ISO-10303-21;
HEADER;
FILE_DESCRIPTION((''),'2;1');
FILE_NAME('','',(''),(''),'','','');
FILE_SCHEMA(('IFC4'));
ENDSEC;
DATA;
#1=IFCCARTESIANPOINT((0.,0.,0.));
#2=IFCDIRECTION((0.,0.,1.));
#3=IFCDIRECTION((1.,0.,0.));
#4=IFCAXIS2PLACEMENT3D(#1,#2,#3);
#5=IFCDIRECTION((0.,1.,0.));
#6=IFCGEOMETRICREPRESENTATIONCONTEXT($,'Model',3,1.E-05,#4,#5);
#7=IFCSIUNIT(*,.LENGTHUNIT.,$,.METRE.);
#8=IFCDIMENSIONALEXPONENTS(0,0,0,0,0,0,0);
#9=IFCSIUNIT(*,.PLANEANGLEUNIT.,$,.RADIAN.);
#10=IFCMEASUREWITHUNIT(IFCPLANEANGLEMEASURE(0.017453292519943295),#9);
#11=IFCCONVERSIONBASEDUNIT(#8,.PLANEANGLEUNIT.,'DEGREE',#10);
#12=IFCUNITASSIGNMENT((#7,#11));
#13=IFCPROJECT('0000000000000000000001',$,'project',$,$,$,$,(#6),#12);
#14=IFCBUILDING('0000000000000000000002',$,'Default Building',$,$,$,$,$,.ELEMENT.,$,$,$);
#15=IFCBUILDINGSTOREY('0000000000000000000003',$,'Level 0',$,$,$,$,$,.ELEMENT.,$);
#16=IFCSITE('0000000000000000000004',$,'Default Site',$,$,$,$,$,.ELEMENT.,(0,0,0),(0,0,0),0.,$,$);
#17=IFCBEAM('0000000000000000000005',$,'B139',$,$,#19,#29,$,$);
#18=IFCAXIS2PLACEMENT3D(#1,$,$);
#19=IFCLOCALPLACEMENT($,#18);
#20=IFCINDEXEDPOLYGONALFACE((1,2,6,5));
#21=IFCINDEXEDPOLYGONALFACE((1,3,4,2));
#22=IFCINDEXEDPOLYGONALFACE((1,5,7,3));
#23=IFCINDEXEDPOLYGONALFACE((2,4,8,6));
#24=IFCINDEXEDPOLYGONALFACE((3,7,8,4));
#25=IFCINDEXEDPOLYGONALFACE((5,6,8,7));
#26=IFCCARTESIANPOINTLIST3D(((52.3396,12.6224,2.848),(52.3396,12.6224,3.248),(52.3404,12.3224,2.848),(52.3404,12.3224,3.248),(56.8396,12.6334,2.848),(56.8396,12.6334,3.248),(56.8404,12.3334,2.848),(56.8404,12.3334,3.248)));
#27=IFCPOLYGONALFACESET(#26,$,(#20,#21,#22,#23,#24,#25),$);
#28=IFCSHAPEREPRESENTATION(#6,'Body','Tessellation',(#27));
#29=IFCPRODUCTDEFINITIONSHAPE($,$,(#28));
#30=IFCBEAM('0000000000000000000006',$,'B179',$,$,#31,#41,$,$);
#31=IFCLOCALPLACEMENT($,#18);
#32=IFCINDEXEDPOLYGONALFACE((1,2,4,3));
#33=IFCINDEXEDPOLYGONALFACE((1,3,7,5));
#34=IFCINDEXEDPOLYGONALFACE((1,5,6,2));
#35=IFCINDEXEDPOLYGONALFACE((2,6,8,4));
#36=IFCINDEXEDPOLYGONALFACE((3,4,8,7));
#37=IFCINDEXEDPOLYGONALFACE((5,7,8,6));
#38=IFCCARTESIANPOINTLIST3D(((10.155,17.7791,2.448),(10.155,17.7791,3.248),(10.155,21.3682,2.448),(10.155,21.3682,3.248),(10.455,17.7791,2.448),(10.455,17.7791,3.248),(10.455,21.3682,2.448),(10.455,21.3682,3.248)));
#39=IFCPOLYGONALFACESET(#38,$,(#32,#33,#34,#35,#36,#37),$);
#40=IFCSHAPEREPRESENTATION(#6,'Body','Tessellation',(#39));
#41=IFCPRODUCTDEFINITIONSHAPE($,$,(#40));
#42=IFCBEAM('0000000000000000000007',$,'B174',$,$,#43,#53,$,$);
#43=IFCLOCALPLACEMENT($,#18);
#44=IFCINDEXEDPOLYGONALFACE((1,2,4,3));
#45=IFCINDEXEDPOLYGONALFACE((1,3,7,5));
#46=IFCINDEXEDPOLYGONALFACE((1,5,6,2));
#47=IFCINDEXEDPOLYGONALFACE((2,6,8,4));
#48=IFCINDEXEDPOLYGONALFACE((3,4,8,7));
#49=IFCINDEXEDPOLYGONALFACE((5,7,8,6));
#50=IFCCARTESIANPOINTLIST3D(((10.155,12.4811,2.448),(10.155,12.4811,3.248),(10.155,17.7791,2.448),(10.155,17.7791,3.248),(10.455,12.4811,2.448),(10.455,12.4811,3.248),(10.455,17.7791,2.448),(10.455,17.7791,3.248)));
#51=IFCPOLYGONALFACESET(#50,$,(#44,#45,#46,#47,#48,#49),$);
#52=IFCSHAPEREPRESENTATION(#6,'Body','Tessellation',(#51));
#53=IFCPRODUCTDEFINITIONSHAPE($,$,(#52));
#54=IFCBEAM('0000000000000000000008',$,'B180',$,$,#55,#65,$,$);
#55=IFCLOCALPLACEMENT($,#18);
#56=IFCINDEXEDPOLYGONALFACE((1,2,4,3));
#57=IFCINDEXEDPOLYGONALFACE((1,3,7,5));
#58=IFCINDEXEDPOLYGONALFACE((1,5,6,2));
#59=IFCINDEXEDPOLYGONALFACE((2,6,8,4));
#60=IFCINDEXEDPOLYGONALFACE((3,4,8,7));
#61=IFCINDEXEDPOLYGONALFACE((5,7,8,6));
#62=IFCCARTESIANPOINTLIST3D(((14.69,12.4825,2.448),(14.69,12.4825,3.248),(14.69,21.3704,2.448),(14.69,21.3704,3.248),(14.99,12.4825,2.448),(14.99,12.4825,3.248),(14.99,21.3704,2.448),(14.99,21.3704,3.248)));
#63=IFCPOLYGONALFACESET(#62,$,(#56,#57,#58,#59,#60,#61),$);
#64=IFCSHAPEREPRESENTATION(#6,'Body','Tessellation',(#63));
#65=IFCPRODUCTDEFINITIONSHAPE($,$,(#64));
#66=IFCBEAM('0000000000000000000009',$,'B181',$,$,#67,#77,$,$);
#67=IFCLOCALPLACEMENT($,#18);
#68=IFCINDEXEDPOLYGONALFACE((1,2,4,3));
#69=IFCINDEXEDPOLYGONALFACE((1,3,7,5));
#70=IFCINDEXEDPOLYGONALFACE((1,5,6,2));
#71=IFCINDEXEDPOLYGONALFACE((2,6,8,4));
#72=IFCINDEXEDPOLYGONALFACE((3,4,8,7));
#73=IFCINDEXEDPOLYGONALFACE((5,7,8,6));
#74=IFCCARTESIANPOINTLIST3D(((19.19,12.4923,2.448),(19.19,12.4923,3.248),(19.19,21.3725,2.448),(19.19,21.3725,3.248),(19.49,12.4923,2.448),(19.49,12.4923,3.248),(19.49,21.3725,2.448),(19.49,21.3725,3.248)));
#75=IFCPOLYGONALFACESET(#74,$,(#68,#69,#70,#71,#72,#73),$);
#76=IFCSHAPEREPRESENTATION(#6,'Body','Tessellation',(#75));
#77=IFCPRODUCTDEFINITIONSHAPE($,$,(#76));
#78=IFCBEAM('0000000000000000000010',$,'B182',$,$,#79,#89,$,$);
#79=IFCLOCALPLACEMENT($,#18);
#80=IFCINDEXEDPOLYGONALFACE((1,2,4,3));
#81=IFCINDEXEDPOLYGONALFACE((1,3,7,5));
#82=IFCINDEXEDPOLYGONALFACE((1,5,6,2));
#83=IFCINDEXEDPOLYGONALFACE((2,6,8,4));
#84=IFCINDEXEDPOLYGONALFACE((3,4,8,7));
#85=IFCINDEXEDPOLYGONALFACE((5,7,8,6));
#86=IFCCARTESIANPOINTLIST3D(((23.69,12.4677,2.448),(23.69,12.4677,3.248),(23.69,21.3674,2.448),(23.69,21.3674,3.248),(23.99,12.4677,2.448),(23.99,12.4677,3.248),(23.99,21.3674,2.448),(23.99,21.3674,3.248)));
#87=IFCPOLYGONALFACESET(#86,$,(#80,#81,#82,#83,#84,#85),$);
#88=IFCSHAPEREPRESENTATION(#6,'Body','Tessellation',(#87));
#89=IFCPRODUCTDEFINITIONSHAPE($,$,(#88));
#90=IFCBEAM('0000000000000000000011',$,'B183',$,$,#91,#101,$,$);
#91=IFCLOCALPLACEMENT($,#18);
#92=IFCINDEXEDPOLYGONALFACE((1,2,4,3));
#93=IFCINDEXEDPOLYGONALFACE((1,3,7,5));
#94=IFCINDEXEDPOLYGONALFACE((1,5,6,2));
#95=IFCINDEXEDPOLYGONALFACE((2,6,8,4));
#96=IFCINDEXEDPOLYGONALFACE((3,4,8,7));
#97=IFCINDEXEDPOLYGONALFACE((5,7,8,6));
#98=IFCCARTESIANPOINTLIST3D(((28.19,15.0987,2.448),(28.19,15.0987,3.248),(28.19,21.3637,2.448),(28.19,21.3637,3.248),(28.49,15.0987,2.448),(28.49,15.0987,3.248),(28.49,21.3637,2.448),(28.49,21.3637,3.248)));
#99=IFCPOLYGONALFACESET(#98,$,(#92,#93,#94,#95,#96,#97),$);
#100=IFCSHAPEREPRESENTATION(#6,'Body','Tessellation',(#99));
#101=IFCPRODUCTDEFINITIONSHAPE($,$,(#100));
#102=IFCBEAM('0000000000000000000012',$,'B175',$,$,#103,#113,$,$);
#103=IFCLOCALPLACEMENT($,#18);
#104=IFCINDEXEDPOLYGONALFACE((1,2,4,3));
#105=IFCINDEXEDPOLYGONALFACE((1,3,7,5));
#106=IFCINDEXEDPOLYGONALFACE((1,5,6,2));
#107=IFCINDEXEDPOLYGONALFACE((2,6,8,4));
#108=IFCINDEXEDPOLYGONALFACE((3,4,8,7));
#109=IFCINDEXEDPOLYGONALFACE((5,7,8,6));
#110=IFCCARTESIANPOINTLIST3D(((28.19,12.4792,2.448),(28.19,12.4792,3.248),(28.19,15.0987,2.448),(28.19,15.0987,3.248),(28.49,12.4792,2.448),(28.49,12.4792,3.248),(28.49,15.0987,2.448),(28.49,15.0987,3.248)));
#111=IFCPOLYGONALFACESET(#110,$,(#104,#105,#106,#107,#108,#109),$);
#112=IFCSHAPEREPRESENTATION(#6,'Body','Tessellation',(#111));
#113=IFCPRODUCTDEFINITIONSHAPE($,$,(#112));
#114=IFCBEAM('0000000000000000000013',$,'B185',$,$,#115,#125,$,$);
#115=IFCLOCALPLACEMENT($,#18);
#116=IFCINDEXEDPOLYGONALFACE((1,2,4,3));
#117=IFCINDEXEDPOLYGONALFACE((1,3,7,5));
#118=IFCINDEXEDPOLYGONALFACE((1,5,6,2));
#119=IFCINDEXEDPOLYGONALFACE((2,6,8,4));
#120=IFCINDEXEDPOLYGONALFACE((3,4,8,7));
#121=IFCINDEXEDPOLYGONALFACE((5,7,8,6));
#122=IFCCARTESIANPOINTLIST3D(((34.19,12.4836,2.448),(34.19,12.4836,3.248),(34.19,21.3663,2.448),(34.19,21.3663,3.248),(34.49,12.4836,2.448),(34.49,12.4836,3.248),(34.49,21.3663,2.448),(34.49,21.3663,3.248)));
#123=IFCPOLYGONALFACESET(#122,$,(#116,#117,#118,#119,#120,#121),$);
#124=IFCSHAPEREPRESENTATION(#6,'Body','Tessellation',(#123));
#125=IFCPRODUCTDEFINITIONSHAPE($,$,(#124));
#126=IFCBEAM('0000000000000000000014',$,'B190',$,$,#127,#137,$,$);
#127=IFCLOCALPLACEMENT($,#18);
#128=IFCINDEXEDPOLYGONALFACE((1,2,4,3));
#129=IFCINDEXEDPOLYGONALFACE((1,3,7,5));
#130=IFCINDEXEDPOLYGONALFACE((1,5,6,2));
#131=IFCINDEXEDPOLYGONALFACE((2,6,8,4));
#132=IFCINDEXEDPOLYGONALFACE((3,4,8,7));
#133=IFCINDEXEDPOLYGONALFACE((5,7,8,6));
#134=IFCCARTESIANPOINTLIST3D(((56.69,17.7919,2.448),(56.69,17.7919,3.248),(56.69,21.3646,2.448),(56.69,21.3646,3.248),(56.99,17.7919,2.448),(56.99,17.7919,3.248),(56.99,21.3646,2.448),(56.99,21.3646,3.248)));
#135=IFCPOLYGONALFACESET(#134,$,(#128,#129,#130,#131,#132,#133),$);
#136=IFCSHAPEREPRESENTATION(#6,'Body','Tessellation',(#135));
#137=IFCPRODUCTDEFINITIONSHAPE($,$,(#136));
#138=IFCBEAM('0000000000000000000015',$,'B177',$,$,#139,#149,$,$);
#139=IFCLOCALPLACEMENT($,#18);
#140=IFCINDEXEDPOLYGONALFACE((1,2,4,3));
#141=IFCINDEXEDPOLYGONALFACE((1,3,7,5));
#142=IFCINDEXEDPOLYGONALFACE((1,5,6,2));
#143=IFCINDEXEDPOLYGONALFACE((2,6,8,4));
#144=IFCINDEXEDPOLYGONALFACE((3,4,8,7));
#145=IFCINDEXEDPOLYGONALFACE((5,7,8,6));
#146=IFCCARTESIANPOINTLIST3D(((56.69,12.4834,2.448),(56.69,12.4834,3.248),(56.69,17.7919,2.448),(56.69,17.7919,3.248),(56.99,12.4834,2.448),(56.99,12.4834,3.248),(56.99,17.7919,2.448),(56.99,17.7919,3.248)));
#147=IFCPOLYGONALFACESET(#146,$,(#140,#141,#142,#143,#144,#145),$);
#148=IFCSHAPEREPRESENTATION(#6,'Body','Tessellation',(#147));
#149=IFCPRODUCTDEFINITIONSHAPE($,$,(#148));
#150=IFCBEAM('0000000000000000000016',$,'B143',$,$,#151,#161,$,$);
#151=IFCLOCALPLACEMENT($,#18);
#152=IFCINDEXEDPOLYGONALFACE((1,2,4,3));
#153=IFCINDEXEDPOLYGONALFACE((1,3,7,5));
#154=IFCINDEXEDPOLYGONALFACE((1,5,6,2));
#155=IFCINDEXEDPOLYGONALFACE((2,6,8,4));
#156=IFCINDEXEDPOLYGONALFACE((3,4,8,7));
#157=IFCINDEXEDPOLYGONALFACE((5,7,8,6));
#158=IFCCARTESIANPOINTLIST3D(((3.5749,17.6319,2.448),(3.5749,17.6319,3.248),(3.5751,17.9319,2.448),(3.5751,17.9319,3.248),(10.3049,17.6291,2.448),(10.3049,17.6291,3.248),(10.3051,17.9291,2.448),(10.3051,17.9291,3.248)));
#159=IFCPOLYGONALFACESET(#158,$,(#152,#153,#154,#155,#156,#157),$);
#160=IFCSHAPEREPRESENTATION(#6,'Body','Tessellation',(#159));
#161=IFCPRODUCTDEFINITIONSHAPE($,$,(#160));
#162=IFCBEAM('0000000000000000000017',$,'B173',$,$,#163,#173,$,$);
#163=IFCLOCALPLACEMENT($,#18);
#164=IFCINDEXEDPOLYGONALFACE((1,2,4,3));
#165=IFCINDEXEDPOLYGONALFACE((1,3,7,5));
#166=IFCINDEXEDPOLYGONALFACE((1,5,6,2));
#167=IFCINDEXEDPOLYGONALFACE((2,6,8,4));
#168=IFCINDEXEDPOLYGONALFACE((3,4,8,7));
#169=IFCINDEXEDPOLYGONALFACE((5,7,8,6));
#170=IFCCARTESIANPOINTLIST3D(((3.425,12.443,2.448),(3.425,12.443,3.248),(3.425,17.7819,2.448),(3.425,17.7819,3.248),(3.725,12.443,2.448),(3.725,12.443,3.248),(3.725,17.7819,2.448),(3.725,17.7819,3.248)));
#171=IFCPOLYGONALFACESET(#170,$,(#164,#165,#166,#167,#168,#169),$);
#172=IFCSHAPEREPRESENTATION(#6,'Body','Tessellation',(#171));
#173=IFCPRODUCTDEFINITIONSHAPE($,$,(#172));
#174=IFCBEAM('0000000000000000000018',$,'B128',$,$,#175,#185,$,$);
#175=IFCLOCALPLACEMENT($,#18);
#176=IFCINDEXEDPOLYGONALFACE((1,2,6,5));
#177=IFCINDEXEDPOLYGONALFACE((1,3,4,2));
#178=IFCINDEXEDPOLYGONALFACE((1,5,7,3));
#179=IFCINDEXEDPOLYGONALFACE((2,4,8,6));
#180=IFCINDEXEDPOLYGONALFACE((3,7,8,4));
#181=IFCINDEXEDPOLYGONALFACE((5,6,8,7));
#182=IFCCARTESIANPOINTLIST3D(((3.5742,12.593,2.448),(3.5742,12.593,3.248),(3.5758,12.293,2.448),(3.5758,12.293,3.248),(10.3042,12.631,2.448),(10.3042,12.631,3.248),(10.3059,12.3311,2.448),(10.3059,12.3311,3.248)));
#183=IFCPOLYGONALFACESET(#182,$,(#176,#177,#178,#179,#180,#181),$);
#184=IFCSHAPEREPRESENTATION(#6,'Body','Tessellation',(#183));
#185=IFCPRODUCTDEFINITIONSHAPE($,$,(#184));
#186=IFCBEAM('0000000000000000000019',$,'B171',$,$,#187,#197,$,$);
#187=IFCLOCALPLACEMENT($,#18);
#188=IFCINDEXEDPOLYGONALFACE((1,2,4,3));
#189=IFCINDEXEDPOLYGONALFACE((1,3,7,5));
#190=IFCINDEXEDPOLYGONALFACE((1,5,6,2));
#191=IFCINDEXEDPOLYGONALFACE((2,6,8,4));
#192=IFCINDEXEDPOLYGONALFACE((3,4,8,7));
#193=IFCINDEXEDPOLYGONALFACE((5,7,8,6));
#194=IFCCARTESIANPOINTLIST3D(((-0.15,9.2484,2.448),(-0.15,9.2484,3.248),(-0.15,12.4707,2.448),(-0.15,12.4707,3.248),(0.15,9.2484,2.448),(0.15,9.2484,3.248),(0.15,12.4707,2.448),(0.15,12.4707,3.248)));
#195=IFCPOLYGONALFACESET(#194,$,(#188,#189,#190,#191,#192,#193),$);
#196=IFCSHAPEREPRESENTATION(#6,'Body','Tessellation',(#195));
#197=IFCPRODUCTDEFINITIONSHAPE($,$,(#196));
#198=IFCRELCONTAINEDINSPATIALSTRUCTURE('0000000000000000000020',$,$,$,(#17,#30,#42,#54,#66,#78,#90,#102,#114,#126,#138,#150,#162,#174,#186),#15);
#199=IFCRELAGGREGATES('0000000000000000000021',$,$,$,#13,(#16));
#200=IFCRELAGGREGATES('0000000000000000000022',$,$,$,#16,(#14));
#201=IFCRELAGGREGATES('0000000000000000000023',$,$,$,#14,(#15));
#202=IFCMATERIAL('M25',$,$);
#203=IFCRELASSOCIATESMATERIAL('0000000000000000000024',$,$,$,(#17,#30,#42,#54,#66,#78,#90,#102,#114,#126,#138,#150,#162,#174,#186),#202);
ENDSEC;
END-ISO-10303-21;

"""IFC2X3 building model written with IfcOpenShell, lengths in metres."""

from ifc_helpers import new_model, entity, si_unit, converted_unit, direction, frame, frame_2d, origin_with_axes, place, context, project, spatial, rectangle, extrude, material, element, save


model = new_model("IFC2X3")

# Units and contexts
model_context = context("Model", 3, precision=1e-05, world=origin_with_axes(), true_north=direction((0.0, 1.0, 0.0)))
ifc_project = project(units=[si_unit("LENGTHUNIT", "METRE"), converted_unit("PLANEANGLEUNIT", "DEGREE", entity("IfcPlaneAngleMeasure", 0.017453292519943295), si_unit("PLANEANGLEUNIT", "RADIAN"), dimensions=[0, 0, 0, 0, 0, 0, 0])], contexts=[model_context])

# Site, building, storey
site = spatial("IfcSite", under=ifc_project, Name="Default Site", CompositionType="ELEMENT", RefLatitude=(0, 0, 0), RefLongitude=(0, 0, 0), RefElevation=0.0)
building = spatial("IfcBuilding", under=site, Name="Default Building", CompositionType="ELEMENT")
storey = spatial("IfcBuildingStorey", under=building, Name="Level 0", CompositionType="ELEMENT")

# Beams
ifc_material = material(Name="M25")
placement = place(None, origin_with_axes())
element("IfcBeam", 1, at=placement, inside=storey, material=ifc_material, Name="B139", context=model_context, shape_type="SweptSolid", body=[
    extrude(rectangle(XDim=0.3, YDim=0.4, at=frame_2d((0.0, 0.0), x_axis=(0.0, 1.0, 0.0))), frame((52.34, 12.4724, 3.048), z_axis=(0.999997, 0.002456, 0.0), x_axis=(0.0, 0.0, -1.0)), (0.0, 0.0, 1.0), 4.5),
])
element("IfcBeam", 2, at=placement, inside=storey, material=ifc_material, Name="B179", context=model_context, shape_type="SweptSolid", body=[
    extrude(rectangle(XDim=0.3, YDim=0.8, at=frame_2d((0.0, 0.0), x_axis=(0.0, 1.0, 0.0))), frame((10.305, 21.3682, 2.848), z_axis=(0.0, -1.0, 0.0), x_axis=(0.0, 0.0, -1.0)), (0.0, 0.0, 1.0), 3.5891),
])
element("IfcBeam", 3, at=placement, inside=storey, material=ifc_material, Name="B174", context=model_context, shape_type="SweptSolid", body=[
    extrude(rectangle(XDim=0.3, YDim=0.8, at=frame_2d((0.0, 0.0), x_axis=(0.0, 1.0, 0.0))), frame((10.305, 17.7791, 2.848), z_axis=(0.0, -1.0, 0.0), x_axis=(0.0, 0.0, -1.0)), (0.0, 0.0, 1.0), 5.298),
])
element("IfcBeam", 4, at=placement, inside=storey, material=ifc_material, Name="B180", context=model_context, shape_type="SweptSolid", body=[
    extrude(rectangle(XDim=0.3, YDim=0.8, at=frame_2d((0.0, 0.0), x_axis=(0.0, 1.0, 0.0))), frame((14.84, 21.3704, 2.848), z_axis=(0.0, -1.0, 0.0), x_axis=(0.0, 0.0, -1.0)), (0.0, 0.0, 1.0), 8.8879),
])
element("IfcBeam", 5, at=placement, inside=storey, material=ifc_material, Name="B181", context=model_context, shape_type="SweptSolid", body=[
    extrude(rectangle(XDim=0.3, YDim=0.8, at=frame_2d((0.0, 0.0), x_axis=(0.0, 1.0, 0.0))), frame((19.34, 21.3725, 2.848), z_axis=(0.0, -1.0, 0.0), x_axis=(0.0, 0.0, -1.0)), (0.0, 0.0, 1.0), 8.8802),
])
element("IfcBeam", 6, at=placement, inside=storey, material=ifc_material, Name="B182", context=model_context, shape_type="SweptSolid", body=[
    extrude(rectangle(XDim=0.3, YDim=0.8, at=frame_2d((0.0, 0.0), x_axis=(0.0, 1.0, 0.0))), frame((23.84, 21.3674, 2.848), z_axis=(0.0, -1.0, 0.0), x_axis=(0.0, 0.0, -1.0)), (0.0, 0.0, 1.0), 8.8997),
])
element("IfcBeam", 7, at=placement, inside=storey, material=ifc_material, Name="B183", context=model_context, shape_type="SweptSolid", body=[
    extrude(rectangle(XDim=0.3, YDim=0.8, at=frame_2d((0.0, 0.0), x_axis=(0.0, 1.0, 0.0))), frame((28.34, 21.3637, 2.848), z_axis=(0.0, -1.0, 0.0), x_axis=(0.0, 0.0, -1.0)), (0.0, 0.0, 1.0), 6.265),
])
element("IfcBeam", 8, at=placement, inside=storey, material=ifc_material, Name="B175", context=model_context, shape_type="SweptSolid", body=[
    extrude(rectangle(XDim=0.3, YDim=0.8, at=frame_2d((0.0, 0.0), x_axis=(0.0, 1.0, 0.0))), frame((28.34, 15.0987, 2.848), z_axis=(0.0, -1.0, 0.0), x_axis=(0.0, 0.0, -1.0)), (0.0, 0.0, 1.0), 2.6195),
])
element("IfcBeam", 9, at=placement, inside=storey, material=ifc_material, Name="B185", context=model_context, shape_type="SweptSolid", body=[
    extrude(rectangle(XDim=0.3, YDim=0.8, at=frame_2d((0.0, 0.0), x_axis=(0.0, 1.0, 0.0))), frame((34.34, 12.4836, 2.848), z_axis=(0.0, 1.0, 0.0), x_axis=(0.0, 0.0, -1.0)), (0.0, 0.0, 1.0), 8.8827),
])
element("IfcBeam", 10, at=placement, inside=storey, material=ifc_material, Name="B190", context=model_context, shape_type="SweptSolid", body=[
    extrude(rectangle(XDim=0.3, YDim=0.8, at=frame_2d((0.0, 0.0), x_axis=(0.0, 1.0, 0.0))), frame((56.84, 17.7919, 2.848), z_axis=(0.0, 1.0, 0.0), x_axis=(0.0, 0.0, -1.0)), (0.0, 0.0, 1.0), 3.5727),
])
element("IfcBeam", 11, at=placement, inside=storey, material=ifc_material, Name="B177", context=model_context, shape_type="SweptSolid", body=[
    extrude(rectangle(XDim=0.3, YDim=0.8, at=frame_2d((0.0, 0.0), x_axis=(0.0, 1.0, 0.0))), frame((56.84, 12.4834, 2.848), z_axis=(0.0, 1.0, 0.0), x_axis=(0.0, 0.0, -1.0)), (0.0, 0.0, 1.0), 5.3085),
])
element("IfcBeam", 12, at=placement, inside=storey, material=ifc_material, Name="B143", context=model_context, shape_type="SweptSolid", body=[
    extrude(rectangle(XDim=0.3, YDim=0.8, at=frame_2d((0.0, 0.0), x_axis=(0.0, 1.0, 0.0))), frame((10.305, 17.7791, 2.848), z_axis=(-1.0, 0.000419, 0.0), x_axis=(0.0, 0.0, -1.0)), (0.0, 0.0, 1.0), 6.73),
])
element("IfcBeam", 13, at=placement, inside=storey, material=ifc_material, Name="B173", context=model_context, shape_type="SweptSolid", body=[
    extrude(rectangle(XDim=0.3, YDim=0.8, at=frame_2d((0.0, 0.0), x_axis=(0.0, 1.0, 0.0))), frame((3.575, 12.443, 2.848), z_axis=(0.0, 1.0, 0.0), x_axis=(0.0, 0.0, -1.0)), (0.0, 0.0, 1.0), 5.3389),
])
element("IfcBeam", 14, at=placement, inside=storey, material=ifc_material, Name="B128", context=model_context, shape_type="SweptSolid", body=[
    extrude(rectangle(XDim=0.3, YDim=0.8, at=frame_2d((0.0, 0.0), x_axis=(0.0, 1.0, 0.0))), frame((3.575, 12.443, 2.848), z_axis=(0.999984, 0.005654, 0.0), x_axis=(0.0, 0.0, -1.0)), (0.0, 0.0, 1.0), 6.7301),
])
element("IfcBeam", 15, at=placement, inside=storey, material=ifc_material, Name="B171", context=model_context, shape_type="SweptSolid", body=[
    extrude(rectangle(XDim=0.3, YDim=0.8, at=frame_2d((0.0, 0.0), x_axis=(0.0, 1.0, 0.0))), frame((0.0, 9.2484, 2.848), z_axis=(0.0, 1.0, 0.0), x_axis=(0.0, 0.0, -1.0)), (0.0, 0.0, 1.0), 3.2223),
])

save(model, "model.ifc")
